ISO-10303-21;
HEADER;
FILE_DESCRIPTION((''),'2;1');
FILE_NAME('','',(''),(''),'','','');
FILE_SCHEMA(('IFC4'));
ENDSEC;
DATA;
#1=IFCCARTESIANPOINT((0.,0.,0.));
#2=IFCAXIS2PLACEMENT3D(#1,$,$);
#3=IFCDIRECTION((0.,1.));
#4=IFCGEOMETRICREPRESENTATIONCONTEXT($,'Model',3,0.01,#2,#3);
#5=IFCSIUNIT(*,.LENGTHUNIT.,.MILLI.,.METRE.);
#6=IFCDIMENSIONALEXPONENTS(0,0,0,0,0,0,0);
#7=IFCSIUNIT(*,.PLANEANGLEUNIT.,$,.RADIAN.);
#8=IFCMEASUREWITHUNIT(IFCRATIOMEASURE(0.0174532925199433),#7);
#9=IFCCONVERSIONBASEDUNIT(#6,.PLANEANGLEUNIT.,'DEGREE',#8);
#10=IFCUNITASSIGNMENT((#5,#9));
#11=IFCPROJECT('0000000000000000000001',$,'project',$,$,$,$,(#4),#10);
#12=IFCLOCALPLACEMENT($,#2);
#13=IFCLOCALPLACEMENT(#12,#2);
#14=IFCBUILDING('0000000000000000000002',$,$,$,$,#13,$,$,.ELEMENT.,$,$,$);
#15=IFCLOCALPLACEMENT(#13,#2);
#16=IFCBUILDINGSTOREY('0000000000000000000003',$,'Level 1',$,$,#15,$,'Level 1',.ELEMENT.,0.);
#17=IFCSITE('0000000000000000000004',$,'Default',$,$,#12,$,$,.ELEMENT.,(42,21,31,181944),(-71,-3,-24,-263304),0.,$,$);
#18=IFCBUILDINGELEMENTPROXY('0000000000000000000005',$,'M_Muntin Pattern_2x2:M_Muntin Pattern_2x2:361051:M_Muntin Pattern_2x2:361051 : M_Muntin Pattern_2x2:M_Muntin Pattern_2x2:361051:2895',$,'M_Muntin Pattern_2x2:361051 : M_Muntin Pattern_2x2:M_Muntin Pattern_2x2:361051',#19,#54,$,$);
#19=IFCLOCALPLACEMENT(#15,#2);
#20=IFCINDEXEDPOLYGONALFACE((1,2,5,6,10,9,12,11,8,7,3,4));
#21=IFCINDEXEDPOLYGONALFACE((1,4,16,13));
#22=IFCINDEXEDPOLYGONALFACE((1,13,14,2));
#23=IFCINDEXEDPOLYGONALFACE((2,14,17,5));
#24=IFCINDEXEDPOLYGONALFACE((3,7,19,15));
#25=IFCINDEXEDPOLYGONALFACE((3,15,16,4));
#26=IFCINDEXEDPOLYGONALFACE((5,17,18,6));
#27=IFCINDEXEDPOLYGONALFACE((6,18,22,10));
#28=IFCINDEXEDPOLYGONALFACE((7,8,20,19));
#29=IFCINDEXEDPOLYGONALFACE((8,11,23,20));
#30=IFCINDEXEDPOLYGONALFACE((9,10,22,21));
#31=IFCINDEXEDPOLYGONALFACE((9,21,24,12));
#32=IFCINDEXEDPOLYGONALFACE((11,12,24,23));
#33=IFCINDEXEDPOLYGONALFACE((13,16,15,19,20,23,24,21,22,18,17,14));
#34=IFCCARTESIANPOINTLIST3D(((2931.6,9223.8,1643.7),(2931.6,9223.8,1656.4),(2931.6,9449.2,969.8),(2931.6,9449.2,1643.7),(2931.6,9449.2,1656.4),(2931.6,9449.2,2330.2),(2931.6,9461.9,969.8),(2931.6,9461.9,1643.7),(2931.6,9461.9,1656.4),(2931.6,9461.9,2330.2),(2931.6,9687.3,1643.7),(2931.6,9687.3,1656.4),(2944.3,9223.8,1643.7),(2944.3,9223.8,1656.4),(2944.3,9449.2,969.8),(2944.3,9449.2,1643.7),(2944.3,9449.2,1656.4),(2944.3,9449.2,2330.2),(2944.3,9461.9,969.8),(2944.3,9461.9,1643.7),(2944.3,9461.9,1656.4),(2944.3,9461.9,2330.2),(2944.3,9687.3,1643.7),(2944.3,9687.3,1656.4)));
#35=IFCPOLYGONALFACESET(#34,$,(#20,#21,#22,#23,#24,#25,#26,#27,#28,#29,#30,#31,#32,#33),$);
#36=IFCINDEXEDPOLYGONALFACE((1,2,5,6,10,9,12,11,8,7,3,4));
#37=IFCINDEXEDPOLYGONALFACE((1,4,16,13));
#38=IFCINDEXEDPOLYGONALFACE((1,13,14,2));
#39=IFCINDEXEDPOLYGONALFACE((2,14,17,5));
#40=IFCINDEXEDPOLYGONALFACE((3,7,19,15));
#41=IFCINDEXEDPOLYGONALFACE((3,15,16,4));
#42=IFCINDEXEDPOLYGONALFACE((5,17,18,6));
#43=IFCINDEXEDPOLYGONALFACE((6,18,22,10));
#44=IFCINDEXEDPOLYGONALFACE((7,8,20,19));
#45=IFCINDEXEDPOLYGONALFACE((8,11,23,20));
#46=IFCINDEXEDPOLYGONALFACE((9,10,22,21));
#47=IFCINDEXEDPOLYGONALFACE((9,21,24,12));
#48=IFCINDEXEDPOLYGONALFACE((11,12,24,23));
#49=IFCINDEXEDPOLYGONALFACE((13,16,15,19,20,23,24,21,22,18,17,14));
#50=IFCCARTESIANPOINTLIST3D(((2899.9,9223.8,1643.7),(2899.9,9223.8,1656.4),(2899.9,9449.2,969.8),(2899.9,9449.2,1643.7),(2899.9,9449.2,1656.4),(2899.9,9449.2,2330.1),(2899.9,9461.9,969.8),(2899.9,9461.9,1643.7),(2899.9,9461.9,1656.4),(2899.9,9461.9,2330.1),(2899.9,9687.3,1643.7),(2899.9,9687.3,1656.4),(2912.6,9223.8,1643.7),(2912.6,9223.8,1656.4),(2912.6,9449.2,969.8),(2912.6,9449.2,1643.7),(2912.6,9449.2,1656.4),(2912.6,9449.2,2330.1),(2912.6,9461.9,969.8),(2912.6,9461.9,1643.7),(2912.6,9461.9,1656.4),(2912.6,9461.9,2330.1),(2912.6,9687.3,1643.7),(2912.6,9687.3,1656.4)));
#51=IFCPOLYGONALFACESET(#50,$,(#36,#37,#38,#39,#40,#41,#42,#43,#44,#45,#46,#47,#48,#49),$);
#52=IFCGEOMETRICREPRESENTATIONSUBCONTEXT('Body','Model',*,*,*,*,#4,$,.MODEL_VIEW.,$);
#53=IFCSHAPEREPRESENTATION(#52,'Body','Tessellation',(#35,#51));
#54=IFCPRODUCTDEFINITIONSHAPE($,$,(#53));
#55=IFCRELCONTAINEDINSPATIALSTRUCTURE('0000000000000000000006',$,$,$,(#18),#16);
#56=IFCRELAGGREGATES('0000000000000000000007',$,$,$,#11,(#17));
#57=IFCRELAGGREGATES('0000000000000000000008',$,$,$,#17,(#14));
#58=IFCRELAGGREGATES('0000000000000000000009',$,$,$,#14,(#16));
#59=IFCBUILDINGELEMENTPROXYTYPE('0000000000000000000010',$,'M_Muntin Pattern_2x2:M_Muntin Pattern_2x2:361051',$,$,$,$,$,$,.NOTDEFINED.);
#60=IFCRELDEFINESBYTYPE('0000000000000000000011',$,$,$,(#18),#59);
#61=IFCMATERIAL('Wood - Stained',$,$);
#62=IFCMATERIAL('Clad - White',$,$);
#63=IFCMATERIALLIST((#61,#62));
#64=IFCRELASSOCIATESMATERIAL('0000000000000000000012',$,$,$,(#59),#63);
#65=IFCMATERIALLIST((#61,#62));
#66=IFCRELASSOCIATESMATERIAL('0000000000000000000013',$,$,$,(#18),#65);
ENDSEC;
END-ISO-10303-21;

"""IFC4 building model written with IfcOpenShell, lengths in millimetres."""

from ifc_helpers import new_model, entity, si_unit, converted_unit, direction, frame, origin, place, context, subcontext, project, spatial, polyline, outline, extrude, source, transform, mapped, material, material_list, type_object, type_shapes, element, save


model = new_model("IFC4")

# Units and contexts
model_context = context("Model", 3, precision=0.01, world=origin(), true_north=direction((0.0, 1.0)))
body_context = subcontext(model_context, "Body", "Model", "MODEL_VIEW")
ifc_project = project(units=[si_unit("LENGTHUNIT", "METRE", prefix="MILLI"), converted_unit("PLANEANGLEUNIT", "DEGREE", entity("IfcRatioMeasure", 0.0174532925199433), si_unit("PLANEANGLEUNIT", "RADIAN"), dimensions=[0, 0, 0, 0, 0, 0, 0])], contexts=[model_context])

# Site, building, storey
site_placement = place(None, origin())
site = spatial("IfcSite", under=ifc_project, at=site_placement, Name="Default", CompositionType="ELEMENT", RefLatitude=(42, 21, 31, 181944), RefLongitude=(-71, -3, -24, -263304), RefElevation=0.0)
building_placement = place(site_placement, origin())
building = spatial("IfcBuilding", under=site, at=building_placement, CompositionType="ELEMENT")
storey_placement = place(building_placement, origin())
storey = spatial("IfcBuildingStorey", under=building, at=storey_placement, Name="Level 1", LongName="Level 1", CompositionType="ELEMENT", Elevation=0.0)

# Building element proxy
ifc_material_1 = material(Name="Wood - Stained")
ifc_material_2 = material(Name="Clad - White")
ifc_material_list_1 = material_list([ifc_material_1, ifc_material_2])
ifc_material_list_2 = material_list([ifc_material_1, ifc_material_2])
building_element_proxy_type_1 = type_object("IfcBuildingElementProxyType", Name="M_Muntin Pattern_2x2:M_Muntin Pattern_2x2:361051", PredefinedType="NOTDEFINED", material=ifc_material_list_2)
shared_shape_1 = source(origin(), body_context, "Body", "SweptSolid", [
    extrude(outline(polyline([(-6.4, -680.1), (6.3, -680.1), (6.3, -6.4), (231.7, -6.4), (231.7, 6.3), (6.3, 6.3), (6.3, 680.2), (-6.4, 680.2), (-6.4, 6.3), (-231.7, 6.3), (-231.7, -6.4), (-6.4, -6.4), (-6.4, -680.1)])), frame((2931.6, 9455.6, 1650.0), z_axis=(1.0, 0.0, 0.0), x_axis=(0.0, -1.0, 0.0)), (0.0, 0.0, 1.0), 12.7),
    extrude(outline(polyline([(-6.4, -680.1), (6.3, -680.1), (6.3, -6.4), (231.7, -6.4), (231.7, 6.3), (6.3, 6.3), (6.3, 680.2), (-6.4, 680.2), (-6.4, 6.3), (-231.7, 6.3), (-231.7, -6.4), (-6.4, -6.4), (-6.4, -680.1)])), frame((2899.9, 9455.6, 1650.0), z_axis=(1.0, 0.0, 0.0), x_axis=(0.0, -1.0, 0.0)), (0.0, 0.0, 1.0), 12.7),
])
type_shapes(building_element_proxy_type_1, [shared_shape_1])
proxy_1_placement = place(storey_placement, origin())
element("IfcBuildingElementProxy", 1, at=proxy_1_placement, inside=storey, type_object=building_element_proxy_type_1, material=ifc_material_list_1, Name="M_Muntin Pattern_2x2:M_Muntin Pattern_2x2:361051:M_Muntin Pattern_2x2:361051 : M_Muntin Pattern_2x2:M_Muntin Pattern_2x2:361051:2895", ObjectType="M_Muntin Pattern_2x2:361051 : M_Muntin Pattern_2x2:M_Muntin Pattern_2x2:361051", context=body_context, shape_type="MappedRepresentation", body=[
    mapped(shared_shape_1, transform((0.0, 0.0, 0.0), scale=1.0)),
])

save(model, "model.ifc")
